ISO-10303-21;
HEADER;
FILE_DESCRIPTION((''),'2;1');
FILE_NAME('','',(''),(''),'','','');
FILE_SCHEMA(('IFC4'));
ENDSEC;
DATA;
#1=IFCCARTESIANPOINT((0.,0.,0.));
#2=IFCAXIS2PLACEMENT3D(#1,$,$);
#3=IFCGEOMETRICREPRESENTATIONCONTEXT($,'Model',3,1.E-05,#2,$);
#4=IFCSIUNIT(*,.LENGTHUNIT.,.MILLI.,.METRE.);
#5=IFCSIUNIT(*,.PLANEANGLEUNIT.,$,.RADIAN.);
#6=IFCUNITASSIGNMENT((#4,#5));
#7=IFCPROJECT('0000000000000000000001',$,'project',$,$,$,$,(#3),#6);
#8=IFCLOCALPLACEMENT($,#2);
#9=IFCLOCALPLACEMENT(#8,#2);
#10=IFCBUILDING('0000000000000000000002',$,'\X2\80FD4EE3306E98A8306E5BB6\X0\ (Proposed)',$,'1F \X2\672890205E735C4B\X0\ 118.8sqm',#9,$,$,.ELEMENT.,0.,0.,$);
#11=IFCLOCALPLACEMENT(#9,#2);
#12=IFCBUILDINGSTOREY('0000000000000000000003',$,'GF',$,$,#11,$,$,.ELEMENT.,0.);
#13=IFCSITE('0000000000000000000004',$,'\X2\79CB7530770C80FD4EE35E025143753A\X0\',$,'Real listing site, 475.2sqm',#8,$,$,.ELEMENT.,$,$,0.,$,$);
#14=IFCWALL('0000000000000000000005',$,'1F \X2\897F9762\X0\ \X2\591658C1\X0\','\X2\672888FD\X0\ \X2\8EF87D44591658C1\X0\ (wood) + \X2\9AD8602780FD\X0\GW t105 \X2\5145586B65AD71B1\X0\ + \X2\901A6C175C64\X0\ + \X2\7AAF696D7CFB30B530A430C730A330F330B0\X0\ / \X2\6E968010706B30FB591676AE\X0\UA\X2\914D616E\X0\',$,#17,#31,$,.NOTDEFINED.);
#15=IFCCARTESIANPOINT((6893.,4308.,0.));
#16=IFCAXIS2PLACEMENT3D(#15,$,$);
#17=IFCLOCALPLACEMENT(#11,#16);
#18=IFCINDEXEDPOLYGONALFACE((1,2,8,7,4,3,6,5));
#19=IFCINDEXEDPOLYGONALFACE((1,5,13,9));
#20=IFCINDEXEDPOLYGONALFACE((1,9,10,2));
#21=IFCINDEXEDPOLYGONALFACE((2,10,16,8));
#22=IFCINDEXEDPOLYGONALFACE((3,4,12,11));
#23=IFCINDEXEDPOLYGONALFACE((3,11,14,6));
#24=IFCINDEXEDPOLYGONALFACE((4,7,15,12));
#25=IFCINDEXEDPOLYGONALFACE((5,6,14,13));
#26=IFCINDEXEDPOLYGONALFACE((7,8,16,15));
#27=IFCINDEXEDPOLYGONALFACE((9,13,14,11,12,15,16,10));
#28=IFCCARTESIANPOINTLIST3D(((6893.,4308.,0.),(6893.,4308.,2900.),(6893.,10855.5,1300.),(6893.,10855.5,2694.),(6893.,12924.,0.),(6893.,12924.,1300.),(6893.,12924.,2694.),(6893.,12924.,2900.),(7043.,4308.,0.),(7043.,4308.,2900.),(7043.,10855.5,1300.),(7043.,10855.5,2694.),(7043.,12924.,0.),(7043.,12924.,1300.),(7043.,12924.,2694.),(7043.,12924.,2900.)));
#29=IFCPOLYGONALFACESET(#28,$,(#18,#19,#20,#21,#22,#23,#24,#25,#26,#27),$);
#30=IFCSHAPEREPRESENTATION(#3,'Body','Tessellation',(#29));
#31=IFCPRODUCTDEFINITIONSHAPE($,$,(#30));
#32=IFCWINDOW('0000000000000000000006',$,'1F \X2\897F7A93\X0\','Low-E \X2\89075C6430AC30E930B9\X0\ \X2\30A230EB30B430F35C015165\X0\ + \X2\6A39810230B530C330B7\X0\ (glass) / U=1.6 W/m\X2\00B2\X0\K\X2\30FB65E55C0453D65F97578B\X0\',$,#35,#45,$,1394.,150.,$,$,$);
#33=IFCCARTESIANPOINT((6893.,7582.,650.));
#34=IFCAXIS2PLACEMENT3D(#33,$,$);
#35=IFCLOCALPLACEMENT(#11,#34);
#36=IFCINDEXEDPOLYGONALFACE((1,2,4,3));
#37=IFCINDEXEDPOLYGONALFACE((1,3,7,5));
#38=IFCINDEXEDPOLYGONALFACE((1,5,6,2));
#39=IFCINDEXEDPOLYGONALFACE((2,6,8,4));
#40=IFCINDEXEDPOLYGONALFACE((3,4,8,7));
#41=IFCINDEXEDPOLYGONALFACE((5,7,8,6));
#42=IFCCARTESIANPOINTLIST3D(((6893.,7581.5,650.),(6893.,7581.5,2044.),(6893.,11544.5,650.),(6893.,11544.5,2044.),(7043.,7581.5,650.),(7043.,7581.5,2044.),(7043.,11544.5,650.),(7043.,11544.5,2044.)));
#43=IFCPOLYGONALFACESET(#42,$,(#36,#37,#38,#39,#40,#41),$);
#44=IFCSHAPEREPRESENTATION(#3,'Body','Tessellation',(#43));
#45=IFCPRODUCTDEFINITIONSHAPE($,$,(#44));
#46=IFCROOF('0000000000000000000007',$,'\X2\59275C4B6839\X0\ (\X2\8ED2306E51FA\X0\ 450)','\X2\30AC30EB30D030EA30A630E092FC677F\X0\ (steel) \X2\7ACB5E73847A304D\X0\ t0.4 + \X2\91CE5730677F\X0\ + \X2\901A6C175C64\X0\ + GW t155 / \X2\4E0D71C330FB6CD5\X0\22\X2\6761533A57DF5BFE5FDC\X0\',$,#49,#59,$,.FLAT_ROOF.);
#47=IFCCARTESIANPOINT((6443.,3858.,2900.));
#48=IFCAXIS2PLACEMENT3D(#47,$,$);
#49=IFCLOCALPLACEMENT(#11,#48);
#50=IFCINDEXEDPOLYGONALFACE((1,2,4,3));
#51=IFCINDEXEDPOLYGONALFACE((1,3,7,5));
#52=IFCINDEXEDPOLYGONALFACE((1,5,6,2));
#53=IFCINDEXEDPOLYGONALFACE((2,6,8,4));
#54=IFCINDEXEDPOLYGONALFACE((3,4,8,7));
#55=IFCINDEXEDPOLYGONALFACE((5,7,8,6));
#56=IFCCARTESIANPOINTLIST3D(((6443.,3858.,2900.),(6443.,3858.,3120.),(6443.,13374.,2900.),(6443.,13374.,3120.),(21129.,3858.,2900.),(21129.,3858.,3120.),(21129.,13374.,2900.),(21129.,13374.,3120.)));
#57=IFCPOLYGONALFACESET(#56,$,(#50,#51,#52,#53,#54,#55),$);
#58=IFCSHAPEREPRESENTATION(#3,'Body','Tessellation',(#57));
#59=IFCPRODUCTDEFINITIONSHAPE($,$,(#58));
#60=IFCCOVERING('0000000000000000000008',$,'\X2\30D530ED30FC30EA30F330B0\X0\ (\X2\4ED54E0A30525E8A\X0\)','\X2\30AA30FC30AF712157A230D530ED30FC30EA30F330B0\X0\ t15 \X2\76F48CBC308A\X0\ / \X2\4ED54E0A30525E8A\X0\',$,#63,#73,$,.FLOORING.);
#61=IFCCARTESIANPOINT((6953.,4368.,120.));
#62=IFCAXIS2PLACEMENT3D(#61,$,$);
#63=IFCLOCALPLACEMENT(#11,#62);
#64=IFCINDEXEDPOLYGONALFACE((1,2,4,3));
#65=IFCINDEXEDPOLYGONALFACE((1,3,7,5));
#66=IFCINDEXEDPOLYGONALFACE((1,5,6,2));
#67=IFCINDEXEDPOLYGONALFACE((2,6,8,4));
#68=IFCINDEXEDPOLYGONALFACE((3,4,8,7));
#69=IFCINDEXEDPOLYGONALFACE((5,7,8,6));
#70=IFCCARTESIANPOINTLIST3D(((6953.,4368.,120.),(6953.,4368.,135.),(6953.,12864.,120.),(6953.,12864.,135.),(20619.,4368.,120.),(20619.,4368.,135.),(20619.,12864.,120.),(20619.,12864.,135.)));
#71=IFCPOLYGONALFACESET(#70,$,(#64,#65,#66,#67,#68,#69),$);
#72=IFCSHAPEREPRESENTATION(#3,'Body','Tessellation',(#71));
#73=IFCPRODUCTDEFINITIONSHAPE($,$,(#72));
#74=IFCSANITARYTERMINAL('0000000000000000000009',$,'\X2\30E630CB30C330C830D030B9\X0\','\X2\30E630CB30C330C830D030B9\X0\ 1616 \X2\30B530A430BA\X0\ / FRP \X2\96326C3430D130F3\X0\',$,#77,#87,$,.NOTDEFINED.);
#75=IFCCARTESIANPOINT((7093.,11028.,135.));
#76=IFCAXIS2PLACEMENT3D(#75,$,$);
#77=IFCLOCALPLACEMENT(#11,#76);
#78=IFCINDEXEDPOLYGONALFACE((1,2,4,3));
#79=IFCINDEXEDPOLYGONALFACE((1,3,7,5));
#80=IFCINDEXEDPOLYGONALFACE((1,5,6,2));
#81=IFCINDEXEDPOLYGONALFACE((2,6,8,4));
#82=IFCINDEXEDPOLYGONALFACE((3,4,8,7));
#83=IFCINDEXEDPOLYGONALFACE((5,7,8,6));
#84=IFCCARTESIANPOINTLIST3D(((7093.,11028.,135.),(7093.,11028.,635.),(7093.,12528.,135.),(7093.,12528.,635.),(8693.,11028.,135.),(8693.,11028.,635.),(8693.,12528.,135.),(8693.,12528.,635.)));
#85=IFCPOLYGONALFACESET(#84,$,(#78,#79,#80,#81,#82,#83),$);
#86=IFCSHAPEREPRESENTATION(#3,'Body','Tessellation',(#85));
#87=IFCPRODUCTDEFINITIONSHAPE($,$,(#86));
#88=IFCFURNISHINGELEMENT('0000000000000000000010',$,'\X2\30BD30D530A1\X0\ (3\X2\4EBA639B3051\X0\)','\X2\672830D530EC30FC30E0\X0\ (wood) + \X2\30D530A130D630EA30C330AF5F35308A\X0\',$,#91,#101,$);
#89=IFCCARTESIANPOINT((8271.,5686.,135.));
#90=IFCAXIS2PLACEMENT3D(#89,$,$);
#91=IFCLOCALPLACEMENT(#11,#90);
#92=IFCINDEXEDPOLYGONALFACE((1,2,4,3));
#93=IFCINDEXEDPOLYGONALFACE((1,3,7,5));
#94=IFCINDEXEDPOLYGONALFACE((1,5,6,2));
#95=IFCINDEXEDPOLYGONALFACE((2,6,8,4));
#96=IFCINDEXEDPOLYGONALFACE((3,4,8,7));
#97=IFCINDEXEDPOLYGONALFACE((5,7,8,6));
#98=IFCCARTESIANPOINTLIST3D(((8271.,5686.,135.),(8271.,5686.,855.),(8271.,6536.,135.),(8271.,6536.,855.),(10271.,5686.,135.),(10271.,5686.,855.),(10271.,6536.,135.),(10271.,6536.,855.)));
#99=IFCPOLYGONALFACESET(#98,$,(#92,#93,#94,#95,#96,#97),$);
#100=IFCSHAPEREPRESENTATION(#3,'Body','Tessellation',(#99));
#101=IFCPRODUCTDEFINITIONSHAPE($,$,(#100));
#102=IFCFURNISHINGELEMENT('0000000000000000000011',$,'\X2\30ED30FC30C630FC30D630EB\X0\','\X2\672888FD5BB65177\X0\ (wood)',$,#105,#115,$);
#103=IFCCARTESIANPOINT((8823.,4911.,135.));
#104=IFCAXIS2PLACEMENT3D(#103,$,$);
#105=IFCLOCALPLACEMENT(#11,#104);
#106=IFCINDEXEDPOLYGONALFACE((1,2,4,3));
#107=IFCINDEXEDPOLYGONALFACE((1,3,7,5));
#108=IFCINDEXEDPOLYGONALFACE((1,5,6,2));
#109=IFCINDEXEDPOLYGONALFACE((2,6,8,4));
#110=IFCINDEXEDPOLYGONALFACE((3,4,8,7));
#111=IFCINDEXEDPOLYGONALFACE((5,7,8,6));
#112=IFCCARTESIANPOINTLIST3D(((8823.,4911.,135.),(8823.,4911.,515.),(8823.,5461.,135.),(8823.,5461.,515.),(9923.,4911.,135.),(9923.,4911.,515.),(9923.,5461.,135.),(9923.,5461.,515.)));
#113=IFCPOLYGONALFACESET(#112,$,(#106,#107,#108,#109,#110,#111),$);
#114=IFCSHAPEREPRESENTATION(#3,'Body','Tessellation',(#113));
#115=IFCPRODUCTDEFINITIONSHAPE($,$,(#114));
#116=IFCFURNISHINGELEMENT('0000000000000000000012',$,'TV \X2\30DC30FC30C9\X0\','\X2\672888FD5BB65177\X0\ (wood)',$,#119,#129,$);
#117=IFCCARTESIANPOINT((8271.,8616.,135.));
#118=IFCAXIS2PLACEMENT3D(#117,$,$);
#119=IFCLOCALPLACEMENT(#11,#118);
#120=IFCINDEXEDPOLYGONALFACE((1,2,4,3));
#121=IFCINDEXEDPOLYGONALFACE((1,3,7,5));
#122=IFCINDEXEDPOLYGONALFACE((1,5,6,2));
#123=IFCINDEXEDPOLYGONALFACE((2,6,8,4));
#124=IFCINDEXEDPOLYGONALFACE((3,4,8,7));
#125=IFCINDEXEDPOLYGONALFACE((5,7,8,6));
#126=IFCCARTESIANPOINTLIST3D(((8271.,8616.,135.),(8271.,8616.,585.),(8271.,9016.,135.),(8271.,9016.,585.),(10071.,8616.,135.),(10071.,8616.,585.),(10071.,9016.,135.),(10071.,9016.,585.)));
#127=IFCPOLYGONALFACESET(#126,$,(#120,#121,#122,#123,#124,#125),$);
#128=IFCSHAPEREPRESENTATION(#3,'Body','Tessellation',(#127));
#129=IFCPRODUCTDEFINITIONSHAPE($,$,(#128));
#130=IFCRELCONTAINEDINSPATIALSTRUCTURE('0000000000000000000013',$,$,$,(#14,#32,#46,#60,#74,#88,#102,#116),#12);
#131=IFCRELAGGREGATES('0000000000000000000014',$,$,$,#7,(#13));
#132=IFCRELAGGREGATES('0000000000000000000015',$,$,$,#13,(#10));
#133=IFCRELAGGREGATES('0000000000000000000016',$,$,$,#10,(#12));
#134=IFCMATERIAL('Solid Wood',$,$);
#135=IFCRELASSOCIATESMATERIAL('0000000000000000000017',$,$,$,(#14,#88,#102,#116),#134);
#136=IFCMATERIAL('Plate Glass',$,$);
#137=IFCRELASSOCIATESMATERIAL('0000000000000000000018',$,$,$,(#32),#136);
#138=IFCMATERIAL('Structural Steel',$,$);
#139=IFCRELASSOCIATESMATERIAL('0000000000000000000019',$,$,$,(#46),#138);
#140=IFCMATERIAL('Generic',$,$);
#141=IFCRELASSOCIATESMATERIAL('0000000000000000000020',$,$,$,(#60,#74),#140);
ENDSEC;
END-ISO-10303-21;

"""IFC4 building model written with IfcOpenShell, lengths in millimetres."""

from ifc_helpers import new_model, si_unit, frame, frame_2d, origin, place, context, project, spatial, rectangle, extrude, material, element, fill, save


model = new_model("IFC4")

# Units and contexts
model_context = context("Model", 3, precision=1e-05, world=origin())
ifc_project = project(units=[si_unit("LENGTHUNIT", "METRE", prefix="MILLI"), si_unit("PLANEANGLEUNIT", "RADIAN")], contexts=[model_context])

# Site, building, storey
site_placement = place(None, origin())
site = spatial("IfcSite", under=ifc_project, at=site_placement, Name="秋田県能代市元町", ObjectType="Real listing site, 475.2sqm", CompositionType="ELEMENT", RefElevation=0.0)
building_placement = place(site_placement, origin())
building = spatial("IfcBuilding", under=site, at=building_placement, Name="能代の風の家 (Proposed)", ObjectType="1F 木造平屋 118.8sqm", CompositionType="ELEMENT", ElevationOfRefHeight=0.0, ElevationOfTerrain=0.0)
storey_placement = place(building_placement, origin())
storey = spatial("IfcBuildingStorey", under=building, at=storey_placement, Name="GF", CompositionType="ELEMENT", Elevation=0.0)

# Shared definitions
ifc_material_1 = material(Name="Solid Wood")

# Shared definitions
ifc_material_2 = material(Name="Plate Glass")

# Wall, opening, window
wall_1_placement = place(storey_placement, frame((6893.0, 4308.0, 0.0)))
wall_1 = element("IfcWall", 1, at=wall_1_placement, inside=storey, material=ifc_material_1, Name="1F 西面 外壁", Description="木製 軸組外壁 (wood) + 高性能GW t105 充填断熱 + 通気層 + 窯業系サイディング / 準耐火・外皮UA配慮", PredefinedType="NOTDEFINED", context=model_context, shape_type="SweptSolid", body=[
    extrude(rectangle(XDim=150.0, YDim=8616.0, at=frame_2d((75.0, 4308.0))), frame((6893.0, 4308.0, 0.0)), (0.0, 0.0, 1.0), 2900.0),
])
opening_1_placement = place(storey_placement, frame((6893.0, 7582.0, 650.0)))
opening_1 = element("IfcOpeningElement", 2, at=opening_1_placement, cuts=wall_1, PredefinedType="NOTDEFINED", context=model_context, shape_type="SweptSolid", body=[
    extrude(rectangle(XDim=150.0, YDim=3963.0, at=frame_2d((75.0, 1981.0))), frame((6893.0, 7582.0, 650.0)), (0.0, 0.0, 1.0), 1394.0),
])
window_1_placement = place(storey_placement, frame((6893.0, 7582.0, 650.0)))
window_1 = element("IfcWindow", 3, at=window_1_placement, inside=storey, material=ifc_material_2, Name="1F 西窓", Description="Low-E 複層ガラス アルゴン封入 + 樹脂サッシ (glass) / U=1.6 W/m²K・日射取得型", OverallHeight=1394.0, OverallWidth=150.0, context=model_context, shape_type="SweptSolid", body=[
    extrude(rectangle(XDim=150.0, YDim=3963.0, at=frame_2d((75.0, 1981.0))), frame((6893.0, 7582.0, 650.0)), (0.0, 0.0, 1.0), 1394.0),
])
fill(opening_1, window_1)

# Roof
ifc_material_3 = material(Name="Structural Steel")
roof_placement = place(storey_placement, frame((6443.0, 3858.0, 2900.0)))
element("IfcRoof", 4, at=roof_placement, inside=storey, material=ifc_material_3, Name="大屋根 (軒の出 450)", Description="ガルバリウム鋼板 (steel) 立平葺き t0.4 + 野地板 + 通気層 + GW t155 / 不燃・法22条区域対応", PredefinedType="FLAT_ROOF", context=model_context, shape_type="SweptSolid", body=[
    extrude(rectangle(XDim=14686.0, YDim=9516.0, at=frame_2d((7343.0, 4758.0))), frame((6443.0, 3858.0, 2900.0)), (0.0, 0.0, 1.0), 220.0),
])

# Covering
ifc_material_4 = material(Name="Generic")
covering_placement = place(storey_placement, frame((6953.0, 4368.0, 120.0)))
element("IfcCovering", 5, at=covering_placement, inside=storey, material=ifc_material_4, Name="フローリング (仕上げ床)", Description="オーク無垢フローリング t15 直貼り / 仕上げ床", PredefinedType="FLOORING", context=model_context, shape_type="SweptSolid", body=[
    extrude(rectangle(XDim=13666.0, YDim=8496.0, at=frame_2d((6833.0, 4248.0))), frame((6953.0, 4368.0, 120.0)), (0.0, 0.0, 1.0), 15.0),
])

# Sanitary terminal
sanitary_terminal_placement = place(storey_placement, frame((7093.0, 11028.0, 135.0)))
element("IfcSanitaryTerminal", 6, at=sanitary_terminal_placement, inside=storey, material=ifc_material_4, Name="ユニットバス", Description="ユニットバス 1616 サイズ / FRP 防水パン", PredefinedType="NOTDEFINED", context=model_context, shape_type="SweptSolid", body=[
    extrude(rectangle(XDim=1600.0, YDim=1500.0, at=frame_2d((800.0, 750.0))), frame((7093.0, 11028.0, 135.0)), (0.0, 0.0, 1.0), 500.0),
])

# Furnishing elements
furnishing_1_placement = place(storey_placement, frame((8271.0, 5686.0, 135.0)))
element("IfcFurnishingElement", 7, at=furnishing_1_placement, inside=storey, material=ifc_material_1, Name="ソファ (3人掛け)", Description="木フレーム (wood) + ファブリック張り", context=model_context, shape_type="SweptSolid", body=[
    extrude(rectangle(XDim=2000.0, YDim=850.0, at=frame_2d((1000.0, 425.0))), frame((8271.0, 5686.0, 135.0)), (0.0, 0.0, 1.0), 720.0),
])
furnishing_2_placement = place(storey_placement, frame((8823.0, 4911.0, 135.0)))
element("IfcFurnishingElement", 8, at=furnishing_2_placement, inside=storey, material=ifc_material_1, Name="ローテーブル", Description="木製家具 (wood)", context=model_context, shape_type="SweptSolid", body=[
    extrude(rectangle(XDim=1100.0, YDim=550.0, at=frame_2d((550.0, 275.0))), frame((8823.0, 4911.0, 135.0)), (0.0, 0.0, 1.0), 380.0),
])
furnishing_3_placement = place(storey_placement, frame((8271.0, 8616.0, 135.0)))
element("IfcFurnishingElement", 9, at=furnishing_3_placement, inside=storey, material=ifc_material_1, Name="TV ボード", Description="木製家具 (wood)", context=model_context, shape_type="SweptSolid", body=[
    extrude(rectangle(XDim=1800.0, YDim=400.0, at=frame_2d((900.0, 200.0))), frame((8271.0, 8616.0, 135.0)), (0.0, 0.0, 1.0), 450.0),
])

save(model, "model.ifc")
